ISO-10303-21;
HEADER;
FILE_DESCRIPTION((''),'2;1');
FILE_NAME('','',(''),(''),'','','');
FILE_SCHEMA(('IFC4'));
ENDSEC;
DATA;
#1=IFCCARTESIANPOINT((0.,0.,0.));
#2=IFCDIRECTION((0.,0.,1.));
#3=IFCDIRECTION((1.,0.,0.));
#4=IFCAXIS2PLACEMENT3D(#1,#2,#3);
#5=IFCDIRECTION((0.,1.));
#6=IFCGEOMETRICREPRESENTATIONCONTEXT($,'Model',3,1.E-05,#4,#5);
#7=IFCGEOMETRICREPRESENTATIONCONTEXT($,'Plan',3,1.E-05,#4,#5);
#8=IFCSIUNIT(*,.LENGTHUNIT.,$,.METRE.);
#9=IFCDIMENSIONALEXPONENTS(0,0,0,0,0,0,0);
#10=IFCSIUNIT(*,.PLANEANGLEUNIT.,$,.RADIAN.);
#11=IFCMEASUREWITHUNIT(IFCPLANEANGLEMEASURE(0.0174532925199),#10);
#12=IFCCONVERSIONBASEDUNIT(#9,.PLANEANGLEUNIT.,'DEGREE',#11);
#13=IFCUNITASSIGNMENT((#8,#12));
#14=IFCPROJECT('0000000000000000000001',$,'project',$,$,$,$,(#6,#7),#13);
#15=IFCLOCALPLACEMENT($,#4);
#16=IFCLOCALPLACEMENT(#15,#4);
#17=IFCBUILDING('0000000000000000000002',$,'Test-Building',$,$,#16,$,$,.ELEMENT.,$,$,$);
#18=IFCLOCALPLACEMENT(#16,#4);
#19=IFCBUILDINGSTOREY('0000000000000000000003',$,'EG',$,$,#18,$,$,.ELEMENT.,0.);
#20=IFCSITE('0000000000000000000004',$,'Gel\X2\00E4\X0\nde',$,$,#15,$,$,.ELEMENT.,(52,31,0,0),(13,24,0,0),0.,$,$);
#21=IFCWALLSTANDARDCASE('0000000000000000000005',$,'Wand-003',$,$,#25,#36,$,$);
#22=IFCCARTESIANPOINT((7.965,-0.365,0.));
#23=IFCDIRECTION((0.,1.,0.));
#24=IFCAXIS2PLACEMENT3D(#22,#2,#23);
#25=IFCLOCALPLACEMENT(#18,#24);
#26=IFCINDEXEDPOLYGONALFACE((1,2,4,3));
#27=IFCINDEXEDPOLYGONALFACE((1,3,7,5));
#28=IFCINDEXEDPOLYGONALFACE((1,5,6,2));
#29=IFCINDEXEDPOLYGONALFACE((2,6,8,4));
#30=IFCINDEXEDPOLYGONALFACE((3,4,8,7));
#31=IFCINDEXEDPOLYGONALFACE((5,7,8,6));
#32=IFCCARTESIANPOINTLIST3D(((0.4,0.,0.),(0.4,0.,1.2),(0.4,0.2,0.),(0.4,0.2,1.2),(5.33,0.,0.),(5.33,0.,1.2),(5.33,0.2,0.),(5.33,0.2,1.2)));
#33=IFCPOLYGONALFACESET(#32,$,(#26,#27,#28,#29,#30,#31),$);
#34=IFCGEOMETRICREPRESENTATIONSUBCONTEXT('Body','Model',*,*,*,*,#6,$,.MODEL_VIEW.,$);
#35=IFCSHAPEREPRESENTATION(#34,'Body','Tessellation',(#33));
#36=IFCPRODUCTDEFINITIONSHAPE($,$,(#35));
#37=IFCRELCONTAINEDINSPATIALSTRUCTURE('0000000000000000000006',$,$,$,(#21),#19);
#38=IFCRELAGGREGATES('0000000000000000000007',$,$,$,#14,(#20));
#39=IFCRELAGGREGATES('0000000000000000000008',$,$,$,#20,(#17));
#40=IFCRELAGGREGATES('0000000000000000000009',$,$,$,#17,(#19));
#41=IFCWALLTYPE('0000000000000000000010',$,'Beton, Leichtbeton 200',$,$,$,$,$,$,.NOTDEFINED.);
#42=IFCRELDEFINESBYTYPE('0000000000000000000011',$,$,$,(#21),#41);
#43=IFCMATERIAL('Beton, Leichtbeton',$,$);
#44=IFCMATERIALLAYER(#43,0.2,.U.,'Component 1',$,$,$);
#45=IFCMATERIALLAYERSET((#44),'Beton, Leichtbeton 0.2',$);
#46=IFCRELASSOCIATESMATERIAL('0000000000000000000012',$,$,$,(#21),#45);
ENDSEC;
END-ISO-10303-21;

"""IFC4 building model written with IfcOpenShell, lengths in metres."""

from ifc_helpers import new_model, entity, si_unit, converted_unit, direction, frame, origin_with_axes, place, context, subcontext, project, spatial, polyline, outline, extrude, material, layer, layer_set, layer_usage, type_object, element, save


model = new_model("IFC4")

# Units and contexts
model_context = context("Model", 3, precision=1e-05, world=origin_with_axes(), true_north=direction((0.0, 1.0)))
plan_context = context("Plan", 3, precision=1e-05, world=origin_with_axes(), true_north=direction((0.0, 1.0)))
body_context = subcontext(model_context, "Body", "Model", "MODEL_VIEW")
ifc_project = project(units=[si_unit("LENGTHUNIT", "METRE"), converted_unit("PLANEANGLEUNIT", "DEGREE", entity("IfcPlaneAngleMeasure", 0.0174532925199), si_unit("PLANEANGLEUNIT", "RADIAN"), dimensions=[0, 0, 0, 0, 0, 0, 0])], contexts=[model_context, plan_context])

# Site, building, storey
site_placement = place(None, origin_with_axes())
site = spatial("IfcSite", under=ifc_project, at=site_placement, Name="Gelände", CompositionType="ELEMENT", RefLatitude=(52, 31, 0, 0), RefLongitude=(13, 24, 0, 0), RefElevation=0.0)
building_placement = place(site_placement, origin_with_axes())
building = spatial("IfcBuilding", under=site, at=building_placement, Name="Test-Building", CompositionType="ELEMENT")
storey_placement = place(building_placement, origin_with_axes())
storey = spatial("IfcBuildingStorey", under=building, at=storey_placement, Name="EG", CompositionType="ELEMENT", Elevation=0.0)

# Wall
ifc_material_1 = material(Name="Beton, Leichtbeton")
ifc_layer_1 = layer(ifc_material_1, 0.2, ventilated="UNKNOWN", Name="Component 1")
ifc_layer_set_1 = layer_set([ifc_layer_1], Name="Beton, Leichtbeton 0.2")
ifc_layer_usage_1 = layer_usage(ifc_layer_set_1, "AXIS2", "POSITIVE", 0.0)
wall_type_1 = type_object("IfcWallType", Name="Beton, Leichtbeton 200", PredefinedType="NOTDEFINED")
wall_1_placement = place(storey_placement, frame((7.965, -0.365, 0.0), z_axis=(0.0, 0.0, 1.0), x_axis=(0.0, 1.0, 0.0)))
element("IfcWallStandardCase", 1, at=wall_1_placement, inside=storey, type_object=wall_type_1, material=ifc_layer_usage_1, Name="Wand-003", context=body_context, shape_type="SweptSolid", body=[
    extrude(outline(polyline([(0.4, 0.0), (5.33, 0.0), (5.33, 0.2), (0.4, 0.2), (0.4, 0.0)])), origin_with_axes(), (0.0, 0.0, 1.0), 1.2),
])

save(model, "model.ifc")
